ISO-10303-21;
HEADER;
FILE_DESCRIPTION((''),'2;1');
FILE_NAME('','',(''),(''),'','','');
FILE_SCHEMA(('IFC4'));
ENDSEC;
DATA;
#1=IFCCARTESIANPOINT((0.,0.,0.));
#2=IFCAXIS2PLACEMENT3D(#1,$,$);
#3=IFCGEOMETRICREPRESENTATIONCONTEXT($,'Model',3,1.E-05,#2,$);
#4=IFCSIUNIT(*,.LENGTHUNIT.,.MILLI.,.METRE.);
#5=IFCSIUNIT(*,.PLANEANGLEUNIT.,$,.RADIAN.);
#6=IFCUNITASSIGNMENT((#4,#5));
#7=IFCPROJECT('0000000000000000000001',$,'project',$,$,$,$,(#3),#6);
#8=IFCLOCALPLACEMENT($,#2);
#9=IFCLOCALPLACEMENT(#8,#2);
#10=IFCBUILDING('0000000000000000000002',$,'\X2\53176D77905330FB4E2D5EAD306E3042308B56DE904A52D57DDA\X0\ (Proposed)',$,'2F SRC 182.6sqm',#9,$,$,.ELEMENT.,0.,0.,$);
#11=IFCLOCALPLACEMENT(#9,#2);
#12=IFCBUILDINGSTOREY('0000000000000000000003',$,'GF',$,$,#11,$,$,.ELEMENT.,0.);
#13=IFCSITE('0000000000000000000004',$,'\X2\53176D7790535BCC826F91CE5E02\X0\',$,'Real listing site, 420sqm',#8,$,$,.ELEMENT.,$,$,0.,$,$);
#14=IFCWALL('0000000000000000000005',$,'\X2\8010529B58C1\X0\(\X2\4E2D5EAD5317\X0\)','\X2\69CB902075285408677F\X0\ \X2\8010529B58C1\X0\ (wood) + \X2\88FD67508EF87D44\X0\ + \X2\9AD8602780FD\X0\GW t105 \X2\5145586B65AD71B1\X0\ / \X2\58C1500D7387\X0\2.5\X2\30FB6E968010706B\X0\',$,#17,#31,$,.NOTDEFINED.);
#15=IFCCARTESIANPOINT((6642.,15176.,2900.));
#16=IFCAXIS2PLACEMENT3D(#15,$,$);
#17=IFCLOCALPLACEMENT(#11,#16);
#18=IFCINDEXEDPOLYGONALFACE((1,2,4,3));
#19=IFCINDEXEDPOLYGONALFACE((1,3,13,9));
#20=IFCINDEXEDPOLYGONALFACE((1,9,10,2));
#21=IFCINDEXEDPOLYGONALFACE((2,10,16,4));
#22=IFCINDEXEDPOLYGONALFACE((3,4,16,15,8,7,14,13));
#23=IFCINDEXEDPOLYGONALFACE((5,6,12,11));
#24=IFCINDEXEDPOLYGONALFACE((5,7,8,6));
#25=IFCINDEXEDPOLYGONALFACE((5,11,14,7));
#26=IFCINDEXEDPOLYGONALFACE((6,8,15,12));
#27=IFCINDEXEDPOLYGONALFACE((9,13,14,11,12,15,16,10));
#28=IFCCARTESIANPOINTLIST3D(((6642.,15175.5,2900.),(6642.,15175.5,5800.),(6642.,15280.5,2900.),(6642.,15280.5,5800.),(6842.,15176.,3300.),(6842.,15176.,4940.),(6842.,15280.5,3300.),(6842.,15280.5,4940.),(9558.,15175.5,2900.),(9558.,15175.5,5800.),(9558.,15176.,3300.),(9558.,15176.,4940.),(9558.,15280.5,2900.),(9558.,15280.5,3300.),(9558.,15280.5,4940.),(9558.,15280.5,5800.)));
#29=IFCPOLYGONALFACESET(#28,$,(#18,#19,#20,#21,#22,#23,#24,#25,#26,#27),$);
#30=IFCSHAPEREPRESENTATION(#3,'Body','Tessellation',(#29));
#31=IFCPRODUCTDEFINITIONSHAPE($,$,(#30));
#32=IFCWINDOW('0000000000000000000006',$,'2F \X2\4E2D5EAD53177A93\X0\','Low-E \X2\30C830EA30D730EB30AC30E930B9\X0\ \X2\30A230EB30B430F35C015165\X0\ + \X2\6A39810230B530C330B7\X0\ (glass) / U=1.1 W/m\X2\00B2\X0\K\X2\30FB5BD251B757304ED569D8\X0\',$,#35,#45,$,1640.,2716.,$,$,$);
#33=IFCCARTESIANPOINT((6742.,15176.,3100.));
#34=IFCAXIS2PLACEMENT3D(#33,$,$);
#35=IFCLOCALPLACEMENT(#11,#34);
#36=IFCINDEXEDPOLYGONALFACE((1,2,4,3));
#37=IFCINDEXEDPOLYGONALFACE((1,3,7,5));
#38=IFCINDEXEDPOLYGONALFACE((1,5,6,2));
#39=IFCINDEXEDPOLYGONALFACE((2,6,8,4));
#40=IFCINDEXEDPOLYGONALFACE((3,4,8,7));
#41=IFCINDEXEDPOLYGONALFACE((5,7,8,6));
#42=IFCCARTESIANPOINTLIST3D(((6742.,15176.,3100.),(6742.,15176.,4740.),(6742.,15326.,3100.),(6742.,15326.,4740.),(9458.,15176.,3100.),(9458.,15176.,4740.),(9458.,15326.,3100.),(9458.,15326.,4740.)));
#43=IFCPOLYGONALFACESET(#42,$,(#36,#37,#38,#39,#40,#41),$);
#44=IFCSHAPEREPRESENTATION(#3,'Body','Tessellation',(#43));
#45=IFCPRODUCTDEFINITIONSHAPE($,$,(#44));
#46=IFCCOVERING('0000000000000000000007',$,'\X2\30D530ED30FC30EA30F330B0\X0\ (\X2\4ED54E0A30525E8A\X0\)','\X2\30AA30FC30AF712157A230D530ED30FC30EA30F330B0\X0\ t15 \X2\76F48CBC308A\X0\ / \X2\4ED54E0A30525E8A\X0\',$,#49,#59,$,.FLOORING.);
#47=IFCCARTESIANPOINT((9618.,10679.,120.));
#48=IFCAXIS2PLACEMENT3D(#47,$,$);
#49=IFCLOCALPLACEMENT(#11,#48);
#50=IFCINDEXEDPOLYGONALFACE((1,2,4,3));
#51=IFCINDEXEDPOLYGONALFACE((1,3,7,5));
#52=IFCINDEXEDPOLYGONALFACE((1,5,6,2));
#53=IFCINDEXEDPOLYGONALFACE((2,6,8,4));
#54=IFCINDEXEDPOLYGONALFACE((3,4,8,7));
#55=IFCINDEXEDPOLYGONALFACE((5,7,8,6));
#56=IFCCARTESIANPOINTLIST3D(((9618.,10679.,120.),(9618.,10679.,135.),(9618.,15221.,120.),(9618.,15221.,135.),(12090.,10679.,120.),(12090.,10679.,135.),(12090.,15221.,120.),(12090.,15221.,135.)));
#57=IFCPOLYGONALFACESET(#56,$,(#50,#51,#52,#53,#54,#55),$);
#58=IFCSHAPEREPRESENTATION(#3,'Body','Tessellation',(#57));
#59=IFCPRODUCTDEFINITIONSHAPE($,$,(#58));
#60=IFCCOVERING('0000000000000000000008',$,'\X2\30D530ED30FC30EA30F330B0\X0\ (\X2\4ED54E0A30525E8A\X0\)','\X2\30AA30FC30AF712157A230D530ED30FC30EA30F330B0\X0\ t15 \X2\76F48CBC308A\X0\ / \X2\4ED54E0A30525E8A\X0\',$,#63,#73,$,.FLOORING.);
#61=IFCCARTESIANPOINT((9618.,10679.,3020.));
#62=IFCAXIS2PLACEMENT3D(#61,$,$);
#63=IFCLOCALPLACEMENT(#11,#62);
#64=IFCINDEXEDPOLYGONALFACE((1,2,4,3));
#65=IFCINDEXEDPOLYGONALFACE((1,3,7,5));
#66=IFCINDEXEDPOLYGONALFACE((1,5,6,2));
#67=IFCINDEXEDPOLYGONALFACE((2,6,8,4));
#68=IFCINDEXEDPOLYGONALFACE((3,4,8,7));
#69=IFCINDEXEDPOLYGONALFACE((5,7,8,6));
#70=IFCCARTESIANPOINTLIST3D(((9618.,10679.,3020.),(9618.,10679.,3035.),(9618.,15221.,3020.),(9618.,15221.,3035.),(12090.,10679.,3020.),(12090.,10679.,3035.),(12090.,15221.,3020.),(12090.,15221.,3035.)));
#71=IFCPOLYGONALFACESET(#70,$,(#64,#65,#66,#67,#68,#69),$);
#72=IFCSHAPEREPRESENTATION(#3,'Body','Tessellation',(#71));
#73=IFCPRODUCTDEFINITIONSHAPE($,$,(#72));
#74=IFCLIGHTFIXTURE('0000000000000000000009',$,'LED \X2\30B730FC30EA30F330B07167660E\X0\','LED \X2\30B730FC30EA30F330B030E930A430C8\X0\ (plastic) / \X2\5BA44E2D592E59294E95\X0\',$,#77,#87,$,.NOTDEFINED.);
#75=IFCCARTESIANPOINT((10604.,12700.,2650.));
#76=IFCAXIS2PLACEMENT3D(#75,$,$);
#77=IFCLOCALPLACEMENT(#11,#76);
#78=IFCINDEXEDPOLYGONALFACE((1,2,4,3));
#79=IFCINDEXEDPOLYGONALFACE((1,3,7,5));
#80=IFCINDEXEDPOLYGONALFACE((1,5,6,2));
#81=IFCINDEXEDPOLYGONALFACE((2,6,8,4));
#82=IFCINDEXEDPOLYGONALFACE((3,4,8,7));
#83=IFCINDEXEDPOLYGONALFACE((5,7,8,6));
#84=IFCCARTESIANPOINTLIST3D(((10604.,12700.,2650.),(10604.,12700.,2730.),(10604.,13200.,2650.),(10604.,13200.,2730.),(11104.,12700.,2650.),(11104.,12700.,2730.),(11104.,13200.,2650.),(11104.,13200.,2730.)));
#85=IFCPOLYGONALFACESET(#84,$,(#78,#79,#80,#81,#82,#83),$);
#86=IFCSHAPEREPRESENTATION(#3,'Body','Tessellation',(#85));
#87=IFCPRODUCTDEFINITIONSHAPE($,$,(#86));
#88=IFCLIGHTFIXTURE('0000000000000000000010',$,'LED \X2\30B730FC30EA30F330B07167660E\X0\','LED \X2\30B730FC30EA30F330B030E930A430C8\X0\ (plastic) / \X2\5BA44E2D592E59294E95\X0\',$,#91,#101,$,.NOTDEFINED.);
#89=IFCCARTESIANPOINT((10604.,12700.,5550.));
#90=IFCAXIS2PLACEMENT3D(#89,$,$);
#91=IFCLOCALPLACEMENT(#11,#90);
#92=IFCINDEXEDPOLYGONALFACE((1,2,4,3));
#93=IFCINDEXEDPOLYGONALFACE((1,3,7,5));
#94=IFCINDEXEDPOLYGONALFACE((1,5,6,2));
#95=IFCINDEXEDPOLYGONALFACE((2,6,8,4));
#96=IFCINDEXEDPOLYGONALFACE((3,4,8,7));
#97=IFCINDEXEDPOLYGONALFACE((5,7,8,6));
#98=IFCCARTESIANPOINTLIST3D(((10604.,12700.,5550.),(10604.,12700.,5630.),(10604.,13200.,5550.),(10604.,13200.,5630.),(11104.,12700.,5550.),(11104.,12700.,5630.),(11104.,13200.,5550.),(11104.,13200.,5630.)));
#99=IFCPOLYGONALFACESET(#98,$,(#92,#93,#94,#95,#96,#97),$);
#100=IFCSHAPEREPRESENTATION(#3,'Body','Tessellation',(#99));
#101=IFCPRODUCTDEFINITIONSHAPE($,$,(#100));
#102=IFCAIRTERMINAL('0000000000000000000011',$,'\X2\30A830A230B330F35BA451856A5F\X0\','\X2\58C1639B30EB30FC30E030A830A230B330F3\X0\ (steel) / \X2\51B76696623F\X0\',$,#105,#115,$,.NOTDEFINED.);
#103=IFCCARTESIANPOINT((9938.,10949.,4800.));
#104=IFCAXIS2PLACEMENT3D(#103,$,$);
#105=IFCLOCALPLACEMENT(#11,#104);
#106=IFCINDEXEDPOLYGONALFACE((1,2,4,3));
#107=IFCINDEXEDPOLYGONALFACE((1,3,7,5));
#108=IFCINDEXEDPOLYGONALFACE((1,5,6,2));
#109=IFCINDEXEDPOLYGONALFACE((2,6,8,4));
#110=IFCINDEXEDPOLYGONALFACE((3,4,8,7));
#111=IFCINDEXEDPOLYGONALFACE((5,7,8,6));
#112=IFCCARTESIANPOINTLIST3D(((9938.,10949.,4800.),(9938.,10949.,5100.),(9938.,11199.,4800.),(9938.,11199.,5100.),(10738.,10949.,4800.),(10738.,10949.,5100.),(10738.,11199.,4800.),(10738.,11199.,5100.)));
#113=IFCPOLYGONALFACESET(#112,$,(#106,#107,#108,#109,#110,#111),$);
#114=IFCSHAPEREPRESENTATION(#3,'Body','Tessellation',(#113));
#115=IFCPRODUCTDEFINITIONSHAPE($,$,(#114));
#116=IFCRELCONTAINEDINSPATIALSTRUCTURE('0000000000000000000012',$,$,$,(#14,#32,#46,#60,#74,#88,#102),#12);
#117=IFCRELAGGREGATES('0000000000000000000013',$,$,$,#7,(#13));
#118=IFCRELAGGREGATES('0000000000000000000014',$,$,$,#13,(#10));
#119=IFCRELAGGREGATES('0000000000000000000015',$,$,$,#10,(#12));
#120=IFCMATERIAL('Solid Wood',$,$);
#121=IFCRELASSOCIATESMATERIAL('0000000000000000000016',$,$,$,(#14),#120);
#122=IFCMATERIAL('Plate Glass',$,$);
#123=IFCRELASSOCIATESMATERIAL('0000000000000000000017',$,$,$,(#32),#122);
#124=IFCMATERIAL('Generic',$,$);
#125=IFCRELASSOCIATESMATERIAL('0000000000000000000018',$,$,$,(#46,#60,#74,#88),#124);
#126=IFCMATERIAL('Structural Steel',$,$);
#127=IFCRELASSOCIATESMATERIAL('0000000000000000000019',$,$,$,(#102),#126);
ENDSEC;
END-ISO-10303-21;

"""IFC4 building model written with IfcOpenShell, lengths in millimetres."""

from ifc_helpers import new_model, si_unit, frame, frame_2d, origin, place, context, project, spatial, rectangle, extrude, material, element, fill, save


model = new_model("IFC4")

# Units and contexts
model_context = context("Model", 3, precision=1e-05, world=origin())
ifc_project = project(units=[si_unit("LENGTHUNIT", "METRE", prefix="MILLI"), si_unit("PLANEANGLEUNIT", "RADIAN")], contexts=[model_context])

# Site, building, storey
site_placement = place(None, origin())
site = spatial("IfcSite", under=ifc_project, at=site_placement, Name="北海道富良野市", ObjectType="Real listing site, 420sqm", CompositionType="ELEMENT", RefElevation=0.0)
building_placement = place(site_placement, origin())
building = spatial("IfcBuilding", under=site, at=building_placement, Name="北海道・中庭のある回遊動線 (Proposed)", ObjectType="2F SRC 182.6sqm", CompositionType="ELEMENT", ElevationOfRefHeight=0.0, ElevationOfTerrain=0.0)
storey_placement = place(building_placement, origin())
storey = spatial("IfcBuildingStorey", under=building, at=storey_placement, Name="GF", CompositionType="ELEMENT", Elevation=0.0)

# Shared definitions
ifc_material_1 = material(Name="Solid Wood")

# Wall, opening, window
ifc_material_2 = material(Name="Plate Glass")
wall_1_placement = place(storey_placement, frame((6642.0, 15176.0, 2900.0)))
wall_1 = element("IfcWall", 1, at=wall_1_placement, inside=storey, material=ifc_material_1, Name="耐力壁(中庭北)", Description="構造用合板 耐力壁 (wood) + 製材軸組 + 高性能GW t105 充填断熱 / 壁倍率2.5・準耐火", PredefinedType="NOTDEFINED", context=model_context, shape_type="SweptSolid", body=[
    extrude(rectangle(XDim=2916.0, YDim=105.0, at=frame_2d((1458.0, 52.0))), frame((6642.0, 15176.0, 2900.0)), (0.0, 0.0, 1.0), 2900.0),
])
opening_1_placement = place(storey_placement, frame((6742.0, 15176.0, 3100.0)))
opening_1 = element("IfcOpeningElement", 2, at=opening_1_placement, cuts=wall_1, PredefinedType="NOTDEFINED", context=model_context, shape_type="SweptSolid", body=[
    extrude(rectangle(XDim=2716.0, YDim=150.0, at=frame_2d((1358.0, 75.0))), frame((6742.0, 15176.0, 3100.0)), (0.0, 0.0, 1.0), 1640.0),
])
window_1_placement = place(storey_placement, frame((6742.0, 15176.0, 3100.0)))
window_1 = element("IfcWindow", 3, at=window_1_placement, inside=storey, material=ifc_material_2, Name="2F 中庭北窓", Description="Low-E トリプルガラス アルゴン封入 + 樹脂サッシ (glass) / U=1.1 W/m²K・寒冷地仕様", OverallHeight=1640.0, OverallWidth=2716.0, context=model_context, shape_type="SweptSolid", body=[
    extrude(rectangle(XDim=2716.0, YDim=150.0, at=frame_2d((1358.0, 75.0))), frame((6742.0, 15176.0, 3100.0)), (0.0, 0.0, 1.0), 1640.0),
])
fill(opening_1, window_1)

# Coverings
ifc_material_3 = material(Name="Generic")
covering_1_placement = place(storey_placement, frame((9618.0, 10679.0, 120.0)))
element("IfcCovering", 4, at=covering_1_placement, inside=storey, material=ifc_material_3, Name="フローリング (仕上げ床)", Description="オーク無垢フローリング t15 直貼り / 仕上げ床", PredefinedType="FLOORING", context=model_context, shape_type="SweptSolid", body=[
    extrude(rectangle(XDim=2472.0, YDim=4542.0, at=frame_2d((1236.0, 2271.0))), frame((9618.0, 10679.0, 120.0)), (0.0, 0.0, 1.0), 15.0),
])
covering_2_placement = place(storey_placement, frame((9618.0, 10679.0, 3020.0)))
element("IfcCovering", 5, at=covering_2_placement, inside=storey, material=ifc_material_3, Name="フローリング (仕上げ床)", Description="オーク無垢フローリング t15 直貼り / 仕上げ床", PredefinedType="FLOORING", context=model_context, shape_type="SweptSolid", body=[
    extrude(rectangle(XDim=2472.0, YDim=4542.0, at=frame_2d((1236.0, 2271.0))), frame((9618.0, 10679.0, 3020.0)), (0.0, 0.0, 1.0), 15.0),
])

# Light fixtures
light_fixture_1_placement = place(storey_placement, frame((10604.0, 12700.0, 2650.0)))
element("IfcLightFixture", 6, at=light_fixture_1_placement, inside=storey, material=ifc_material_3, Name="LED シーリング照明", Description="LED シーリングライト (plastic) / 室中央天井", PredefinedType="NOTDEFINED", context=model_context, shape_type="SweptSolid", body=[
    extrude(rectangle(XDim=500.0, YDim=500.0, at=frame_2d((250.0, 250.0))), frame((10604.0, 12700.0, 2650.0)), (0.0, 0.0, 1.0), 80.0),
])
light_fixture_2_placement = place(storey_placement, frame((10604.0, 12700.0, 5550.0)))
element("IfcLightFixture", 7, at=light_fixture_2_placement, inside=storey, material=ifc_material_3, Name="LED シーリング照明", Description="LED シーリングライト (plastic) / 室中央天井", PredefinedType="NOTDEFINED", context=model_context, shape_type="SweptSolid", body=[
    extrude(rectangle(XDim=500.0, YDim=500.0, at=frame_2d((250.0, 250.0))), frame((10604.0, 12700.0, 5550.0)), (0.0, 0.0, 1.0), 80.0),
])

# Air terminal
ifc_material_4 = material(Name="Structural Steel")
air_terminal_placement = place(storey_placement, frame((9938.0, 10949.0, 4800.0)))
element("IfcAirTerminal", 8, at=air_terminal_placement, inside=storey, material=ifc_material_4, Name="エアコン室内機", Description="壁掛ルームエアコン (steel) / 冷暖房", PredefinedType="NOTDEFINED", context=model_context, shape_type="SweptSolid", body=[
    extrude(rectangle(XDim=800.0, YDim=250.0, at=frame_2d((400.0, 125.0))), frame((9938.0, 10949.0, 4800.0)), (0.0, 0.0, 1.0), 300.0),
])

save(model, "model.ifc")
